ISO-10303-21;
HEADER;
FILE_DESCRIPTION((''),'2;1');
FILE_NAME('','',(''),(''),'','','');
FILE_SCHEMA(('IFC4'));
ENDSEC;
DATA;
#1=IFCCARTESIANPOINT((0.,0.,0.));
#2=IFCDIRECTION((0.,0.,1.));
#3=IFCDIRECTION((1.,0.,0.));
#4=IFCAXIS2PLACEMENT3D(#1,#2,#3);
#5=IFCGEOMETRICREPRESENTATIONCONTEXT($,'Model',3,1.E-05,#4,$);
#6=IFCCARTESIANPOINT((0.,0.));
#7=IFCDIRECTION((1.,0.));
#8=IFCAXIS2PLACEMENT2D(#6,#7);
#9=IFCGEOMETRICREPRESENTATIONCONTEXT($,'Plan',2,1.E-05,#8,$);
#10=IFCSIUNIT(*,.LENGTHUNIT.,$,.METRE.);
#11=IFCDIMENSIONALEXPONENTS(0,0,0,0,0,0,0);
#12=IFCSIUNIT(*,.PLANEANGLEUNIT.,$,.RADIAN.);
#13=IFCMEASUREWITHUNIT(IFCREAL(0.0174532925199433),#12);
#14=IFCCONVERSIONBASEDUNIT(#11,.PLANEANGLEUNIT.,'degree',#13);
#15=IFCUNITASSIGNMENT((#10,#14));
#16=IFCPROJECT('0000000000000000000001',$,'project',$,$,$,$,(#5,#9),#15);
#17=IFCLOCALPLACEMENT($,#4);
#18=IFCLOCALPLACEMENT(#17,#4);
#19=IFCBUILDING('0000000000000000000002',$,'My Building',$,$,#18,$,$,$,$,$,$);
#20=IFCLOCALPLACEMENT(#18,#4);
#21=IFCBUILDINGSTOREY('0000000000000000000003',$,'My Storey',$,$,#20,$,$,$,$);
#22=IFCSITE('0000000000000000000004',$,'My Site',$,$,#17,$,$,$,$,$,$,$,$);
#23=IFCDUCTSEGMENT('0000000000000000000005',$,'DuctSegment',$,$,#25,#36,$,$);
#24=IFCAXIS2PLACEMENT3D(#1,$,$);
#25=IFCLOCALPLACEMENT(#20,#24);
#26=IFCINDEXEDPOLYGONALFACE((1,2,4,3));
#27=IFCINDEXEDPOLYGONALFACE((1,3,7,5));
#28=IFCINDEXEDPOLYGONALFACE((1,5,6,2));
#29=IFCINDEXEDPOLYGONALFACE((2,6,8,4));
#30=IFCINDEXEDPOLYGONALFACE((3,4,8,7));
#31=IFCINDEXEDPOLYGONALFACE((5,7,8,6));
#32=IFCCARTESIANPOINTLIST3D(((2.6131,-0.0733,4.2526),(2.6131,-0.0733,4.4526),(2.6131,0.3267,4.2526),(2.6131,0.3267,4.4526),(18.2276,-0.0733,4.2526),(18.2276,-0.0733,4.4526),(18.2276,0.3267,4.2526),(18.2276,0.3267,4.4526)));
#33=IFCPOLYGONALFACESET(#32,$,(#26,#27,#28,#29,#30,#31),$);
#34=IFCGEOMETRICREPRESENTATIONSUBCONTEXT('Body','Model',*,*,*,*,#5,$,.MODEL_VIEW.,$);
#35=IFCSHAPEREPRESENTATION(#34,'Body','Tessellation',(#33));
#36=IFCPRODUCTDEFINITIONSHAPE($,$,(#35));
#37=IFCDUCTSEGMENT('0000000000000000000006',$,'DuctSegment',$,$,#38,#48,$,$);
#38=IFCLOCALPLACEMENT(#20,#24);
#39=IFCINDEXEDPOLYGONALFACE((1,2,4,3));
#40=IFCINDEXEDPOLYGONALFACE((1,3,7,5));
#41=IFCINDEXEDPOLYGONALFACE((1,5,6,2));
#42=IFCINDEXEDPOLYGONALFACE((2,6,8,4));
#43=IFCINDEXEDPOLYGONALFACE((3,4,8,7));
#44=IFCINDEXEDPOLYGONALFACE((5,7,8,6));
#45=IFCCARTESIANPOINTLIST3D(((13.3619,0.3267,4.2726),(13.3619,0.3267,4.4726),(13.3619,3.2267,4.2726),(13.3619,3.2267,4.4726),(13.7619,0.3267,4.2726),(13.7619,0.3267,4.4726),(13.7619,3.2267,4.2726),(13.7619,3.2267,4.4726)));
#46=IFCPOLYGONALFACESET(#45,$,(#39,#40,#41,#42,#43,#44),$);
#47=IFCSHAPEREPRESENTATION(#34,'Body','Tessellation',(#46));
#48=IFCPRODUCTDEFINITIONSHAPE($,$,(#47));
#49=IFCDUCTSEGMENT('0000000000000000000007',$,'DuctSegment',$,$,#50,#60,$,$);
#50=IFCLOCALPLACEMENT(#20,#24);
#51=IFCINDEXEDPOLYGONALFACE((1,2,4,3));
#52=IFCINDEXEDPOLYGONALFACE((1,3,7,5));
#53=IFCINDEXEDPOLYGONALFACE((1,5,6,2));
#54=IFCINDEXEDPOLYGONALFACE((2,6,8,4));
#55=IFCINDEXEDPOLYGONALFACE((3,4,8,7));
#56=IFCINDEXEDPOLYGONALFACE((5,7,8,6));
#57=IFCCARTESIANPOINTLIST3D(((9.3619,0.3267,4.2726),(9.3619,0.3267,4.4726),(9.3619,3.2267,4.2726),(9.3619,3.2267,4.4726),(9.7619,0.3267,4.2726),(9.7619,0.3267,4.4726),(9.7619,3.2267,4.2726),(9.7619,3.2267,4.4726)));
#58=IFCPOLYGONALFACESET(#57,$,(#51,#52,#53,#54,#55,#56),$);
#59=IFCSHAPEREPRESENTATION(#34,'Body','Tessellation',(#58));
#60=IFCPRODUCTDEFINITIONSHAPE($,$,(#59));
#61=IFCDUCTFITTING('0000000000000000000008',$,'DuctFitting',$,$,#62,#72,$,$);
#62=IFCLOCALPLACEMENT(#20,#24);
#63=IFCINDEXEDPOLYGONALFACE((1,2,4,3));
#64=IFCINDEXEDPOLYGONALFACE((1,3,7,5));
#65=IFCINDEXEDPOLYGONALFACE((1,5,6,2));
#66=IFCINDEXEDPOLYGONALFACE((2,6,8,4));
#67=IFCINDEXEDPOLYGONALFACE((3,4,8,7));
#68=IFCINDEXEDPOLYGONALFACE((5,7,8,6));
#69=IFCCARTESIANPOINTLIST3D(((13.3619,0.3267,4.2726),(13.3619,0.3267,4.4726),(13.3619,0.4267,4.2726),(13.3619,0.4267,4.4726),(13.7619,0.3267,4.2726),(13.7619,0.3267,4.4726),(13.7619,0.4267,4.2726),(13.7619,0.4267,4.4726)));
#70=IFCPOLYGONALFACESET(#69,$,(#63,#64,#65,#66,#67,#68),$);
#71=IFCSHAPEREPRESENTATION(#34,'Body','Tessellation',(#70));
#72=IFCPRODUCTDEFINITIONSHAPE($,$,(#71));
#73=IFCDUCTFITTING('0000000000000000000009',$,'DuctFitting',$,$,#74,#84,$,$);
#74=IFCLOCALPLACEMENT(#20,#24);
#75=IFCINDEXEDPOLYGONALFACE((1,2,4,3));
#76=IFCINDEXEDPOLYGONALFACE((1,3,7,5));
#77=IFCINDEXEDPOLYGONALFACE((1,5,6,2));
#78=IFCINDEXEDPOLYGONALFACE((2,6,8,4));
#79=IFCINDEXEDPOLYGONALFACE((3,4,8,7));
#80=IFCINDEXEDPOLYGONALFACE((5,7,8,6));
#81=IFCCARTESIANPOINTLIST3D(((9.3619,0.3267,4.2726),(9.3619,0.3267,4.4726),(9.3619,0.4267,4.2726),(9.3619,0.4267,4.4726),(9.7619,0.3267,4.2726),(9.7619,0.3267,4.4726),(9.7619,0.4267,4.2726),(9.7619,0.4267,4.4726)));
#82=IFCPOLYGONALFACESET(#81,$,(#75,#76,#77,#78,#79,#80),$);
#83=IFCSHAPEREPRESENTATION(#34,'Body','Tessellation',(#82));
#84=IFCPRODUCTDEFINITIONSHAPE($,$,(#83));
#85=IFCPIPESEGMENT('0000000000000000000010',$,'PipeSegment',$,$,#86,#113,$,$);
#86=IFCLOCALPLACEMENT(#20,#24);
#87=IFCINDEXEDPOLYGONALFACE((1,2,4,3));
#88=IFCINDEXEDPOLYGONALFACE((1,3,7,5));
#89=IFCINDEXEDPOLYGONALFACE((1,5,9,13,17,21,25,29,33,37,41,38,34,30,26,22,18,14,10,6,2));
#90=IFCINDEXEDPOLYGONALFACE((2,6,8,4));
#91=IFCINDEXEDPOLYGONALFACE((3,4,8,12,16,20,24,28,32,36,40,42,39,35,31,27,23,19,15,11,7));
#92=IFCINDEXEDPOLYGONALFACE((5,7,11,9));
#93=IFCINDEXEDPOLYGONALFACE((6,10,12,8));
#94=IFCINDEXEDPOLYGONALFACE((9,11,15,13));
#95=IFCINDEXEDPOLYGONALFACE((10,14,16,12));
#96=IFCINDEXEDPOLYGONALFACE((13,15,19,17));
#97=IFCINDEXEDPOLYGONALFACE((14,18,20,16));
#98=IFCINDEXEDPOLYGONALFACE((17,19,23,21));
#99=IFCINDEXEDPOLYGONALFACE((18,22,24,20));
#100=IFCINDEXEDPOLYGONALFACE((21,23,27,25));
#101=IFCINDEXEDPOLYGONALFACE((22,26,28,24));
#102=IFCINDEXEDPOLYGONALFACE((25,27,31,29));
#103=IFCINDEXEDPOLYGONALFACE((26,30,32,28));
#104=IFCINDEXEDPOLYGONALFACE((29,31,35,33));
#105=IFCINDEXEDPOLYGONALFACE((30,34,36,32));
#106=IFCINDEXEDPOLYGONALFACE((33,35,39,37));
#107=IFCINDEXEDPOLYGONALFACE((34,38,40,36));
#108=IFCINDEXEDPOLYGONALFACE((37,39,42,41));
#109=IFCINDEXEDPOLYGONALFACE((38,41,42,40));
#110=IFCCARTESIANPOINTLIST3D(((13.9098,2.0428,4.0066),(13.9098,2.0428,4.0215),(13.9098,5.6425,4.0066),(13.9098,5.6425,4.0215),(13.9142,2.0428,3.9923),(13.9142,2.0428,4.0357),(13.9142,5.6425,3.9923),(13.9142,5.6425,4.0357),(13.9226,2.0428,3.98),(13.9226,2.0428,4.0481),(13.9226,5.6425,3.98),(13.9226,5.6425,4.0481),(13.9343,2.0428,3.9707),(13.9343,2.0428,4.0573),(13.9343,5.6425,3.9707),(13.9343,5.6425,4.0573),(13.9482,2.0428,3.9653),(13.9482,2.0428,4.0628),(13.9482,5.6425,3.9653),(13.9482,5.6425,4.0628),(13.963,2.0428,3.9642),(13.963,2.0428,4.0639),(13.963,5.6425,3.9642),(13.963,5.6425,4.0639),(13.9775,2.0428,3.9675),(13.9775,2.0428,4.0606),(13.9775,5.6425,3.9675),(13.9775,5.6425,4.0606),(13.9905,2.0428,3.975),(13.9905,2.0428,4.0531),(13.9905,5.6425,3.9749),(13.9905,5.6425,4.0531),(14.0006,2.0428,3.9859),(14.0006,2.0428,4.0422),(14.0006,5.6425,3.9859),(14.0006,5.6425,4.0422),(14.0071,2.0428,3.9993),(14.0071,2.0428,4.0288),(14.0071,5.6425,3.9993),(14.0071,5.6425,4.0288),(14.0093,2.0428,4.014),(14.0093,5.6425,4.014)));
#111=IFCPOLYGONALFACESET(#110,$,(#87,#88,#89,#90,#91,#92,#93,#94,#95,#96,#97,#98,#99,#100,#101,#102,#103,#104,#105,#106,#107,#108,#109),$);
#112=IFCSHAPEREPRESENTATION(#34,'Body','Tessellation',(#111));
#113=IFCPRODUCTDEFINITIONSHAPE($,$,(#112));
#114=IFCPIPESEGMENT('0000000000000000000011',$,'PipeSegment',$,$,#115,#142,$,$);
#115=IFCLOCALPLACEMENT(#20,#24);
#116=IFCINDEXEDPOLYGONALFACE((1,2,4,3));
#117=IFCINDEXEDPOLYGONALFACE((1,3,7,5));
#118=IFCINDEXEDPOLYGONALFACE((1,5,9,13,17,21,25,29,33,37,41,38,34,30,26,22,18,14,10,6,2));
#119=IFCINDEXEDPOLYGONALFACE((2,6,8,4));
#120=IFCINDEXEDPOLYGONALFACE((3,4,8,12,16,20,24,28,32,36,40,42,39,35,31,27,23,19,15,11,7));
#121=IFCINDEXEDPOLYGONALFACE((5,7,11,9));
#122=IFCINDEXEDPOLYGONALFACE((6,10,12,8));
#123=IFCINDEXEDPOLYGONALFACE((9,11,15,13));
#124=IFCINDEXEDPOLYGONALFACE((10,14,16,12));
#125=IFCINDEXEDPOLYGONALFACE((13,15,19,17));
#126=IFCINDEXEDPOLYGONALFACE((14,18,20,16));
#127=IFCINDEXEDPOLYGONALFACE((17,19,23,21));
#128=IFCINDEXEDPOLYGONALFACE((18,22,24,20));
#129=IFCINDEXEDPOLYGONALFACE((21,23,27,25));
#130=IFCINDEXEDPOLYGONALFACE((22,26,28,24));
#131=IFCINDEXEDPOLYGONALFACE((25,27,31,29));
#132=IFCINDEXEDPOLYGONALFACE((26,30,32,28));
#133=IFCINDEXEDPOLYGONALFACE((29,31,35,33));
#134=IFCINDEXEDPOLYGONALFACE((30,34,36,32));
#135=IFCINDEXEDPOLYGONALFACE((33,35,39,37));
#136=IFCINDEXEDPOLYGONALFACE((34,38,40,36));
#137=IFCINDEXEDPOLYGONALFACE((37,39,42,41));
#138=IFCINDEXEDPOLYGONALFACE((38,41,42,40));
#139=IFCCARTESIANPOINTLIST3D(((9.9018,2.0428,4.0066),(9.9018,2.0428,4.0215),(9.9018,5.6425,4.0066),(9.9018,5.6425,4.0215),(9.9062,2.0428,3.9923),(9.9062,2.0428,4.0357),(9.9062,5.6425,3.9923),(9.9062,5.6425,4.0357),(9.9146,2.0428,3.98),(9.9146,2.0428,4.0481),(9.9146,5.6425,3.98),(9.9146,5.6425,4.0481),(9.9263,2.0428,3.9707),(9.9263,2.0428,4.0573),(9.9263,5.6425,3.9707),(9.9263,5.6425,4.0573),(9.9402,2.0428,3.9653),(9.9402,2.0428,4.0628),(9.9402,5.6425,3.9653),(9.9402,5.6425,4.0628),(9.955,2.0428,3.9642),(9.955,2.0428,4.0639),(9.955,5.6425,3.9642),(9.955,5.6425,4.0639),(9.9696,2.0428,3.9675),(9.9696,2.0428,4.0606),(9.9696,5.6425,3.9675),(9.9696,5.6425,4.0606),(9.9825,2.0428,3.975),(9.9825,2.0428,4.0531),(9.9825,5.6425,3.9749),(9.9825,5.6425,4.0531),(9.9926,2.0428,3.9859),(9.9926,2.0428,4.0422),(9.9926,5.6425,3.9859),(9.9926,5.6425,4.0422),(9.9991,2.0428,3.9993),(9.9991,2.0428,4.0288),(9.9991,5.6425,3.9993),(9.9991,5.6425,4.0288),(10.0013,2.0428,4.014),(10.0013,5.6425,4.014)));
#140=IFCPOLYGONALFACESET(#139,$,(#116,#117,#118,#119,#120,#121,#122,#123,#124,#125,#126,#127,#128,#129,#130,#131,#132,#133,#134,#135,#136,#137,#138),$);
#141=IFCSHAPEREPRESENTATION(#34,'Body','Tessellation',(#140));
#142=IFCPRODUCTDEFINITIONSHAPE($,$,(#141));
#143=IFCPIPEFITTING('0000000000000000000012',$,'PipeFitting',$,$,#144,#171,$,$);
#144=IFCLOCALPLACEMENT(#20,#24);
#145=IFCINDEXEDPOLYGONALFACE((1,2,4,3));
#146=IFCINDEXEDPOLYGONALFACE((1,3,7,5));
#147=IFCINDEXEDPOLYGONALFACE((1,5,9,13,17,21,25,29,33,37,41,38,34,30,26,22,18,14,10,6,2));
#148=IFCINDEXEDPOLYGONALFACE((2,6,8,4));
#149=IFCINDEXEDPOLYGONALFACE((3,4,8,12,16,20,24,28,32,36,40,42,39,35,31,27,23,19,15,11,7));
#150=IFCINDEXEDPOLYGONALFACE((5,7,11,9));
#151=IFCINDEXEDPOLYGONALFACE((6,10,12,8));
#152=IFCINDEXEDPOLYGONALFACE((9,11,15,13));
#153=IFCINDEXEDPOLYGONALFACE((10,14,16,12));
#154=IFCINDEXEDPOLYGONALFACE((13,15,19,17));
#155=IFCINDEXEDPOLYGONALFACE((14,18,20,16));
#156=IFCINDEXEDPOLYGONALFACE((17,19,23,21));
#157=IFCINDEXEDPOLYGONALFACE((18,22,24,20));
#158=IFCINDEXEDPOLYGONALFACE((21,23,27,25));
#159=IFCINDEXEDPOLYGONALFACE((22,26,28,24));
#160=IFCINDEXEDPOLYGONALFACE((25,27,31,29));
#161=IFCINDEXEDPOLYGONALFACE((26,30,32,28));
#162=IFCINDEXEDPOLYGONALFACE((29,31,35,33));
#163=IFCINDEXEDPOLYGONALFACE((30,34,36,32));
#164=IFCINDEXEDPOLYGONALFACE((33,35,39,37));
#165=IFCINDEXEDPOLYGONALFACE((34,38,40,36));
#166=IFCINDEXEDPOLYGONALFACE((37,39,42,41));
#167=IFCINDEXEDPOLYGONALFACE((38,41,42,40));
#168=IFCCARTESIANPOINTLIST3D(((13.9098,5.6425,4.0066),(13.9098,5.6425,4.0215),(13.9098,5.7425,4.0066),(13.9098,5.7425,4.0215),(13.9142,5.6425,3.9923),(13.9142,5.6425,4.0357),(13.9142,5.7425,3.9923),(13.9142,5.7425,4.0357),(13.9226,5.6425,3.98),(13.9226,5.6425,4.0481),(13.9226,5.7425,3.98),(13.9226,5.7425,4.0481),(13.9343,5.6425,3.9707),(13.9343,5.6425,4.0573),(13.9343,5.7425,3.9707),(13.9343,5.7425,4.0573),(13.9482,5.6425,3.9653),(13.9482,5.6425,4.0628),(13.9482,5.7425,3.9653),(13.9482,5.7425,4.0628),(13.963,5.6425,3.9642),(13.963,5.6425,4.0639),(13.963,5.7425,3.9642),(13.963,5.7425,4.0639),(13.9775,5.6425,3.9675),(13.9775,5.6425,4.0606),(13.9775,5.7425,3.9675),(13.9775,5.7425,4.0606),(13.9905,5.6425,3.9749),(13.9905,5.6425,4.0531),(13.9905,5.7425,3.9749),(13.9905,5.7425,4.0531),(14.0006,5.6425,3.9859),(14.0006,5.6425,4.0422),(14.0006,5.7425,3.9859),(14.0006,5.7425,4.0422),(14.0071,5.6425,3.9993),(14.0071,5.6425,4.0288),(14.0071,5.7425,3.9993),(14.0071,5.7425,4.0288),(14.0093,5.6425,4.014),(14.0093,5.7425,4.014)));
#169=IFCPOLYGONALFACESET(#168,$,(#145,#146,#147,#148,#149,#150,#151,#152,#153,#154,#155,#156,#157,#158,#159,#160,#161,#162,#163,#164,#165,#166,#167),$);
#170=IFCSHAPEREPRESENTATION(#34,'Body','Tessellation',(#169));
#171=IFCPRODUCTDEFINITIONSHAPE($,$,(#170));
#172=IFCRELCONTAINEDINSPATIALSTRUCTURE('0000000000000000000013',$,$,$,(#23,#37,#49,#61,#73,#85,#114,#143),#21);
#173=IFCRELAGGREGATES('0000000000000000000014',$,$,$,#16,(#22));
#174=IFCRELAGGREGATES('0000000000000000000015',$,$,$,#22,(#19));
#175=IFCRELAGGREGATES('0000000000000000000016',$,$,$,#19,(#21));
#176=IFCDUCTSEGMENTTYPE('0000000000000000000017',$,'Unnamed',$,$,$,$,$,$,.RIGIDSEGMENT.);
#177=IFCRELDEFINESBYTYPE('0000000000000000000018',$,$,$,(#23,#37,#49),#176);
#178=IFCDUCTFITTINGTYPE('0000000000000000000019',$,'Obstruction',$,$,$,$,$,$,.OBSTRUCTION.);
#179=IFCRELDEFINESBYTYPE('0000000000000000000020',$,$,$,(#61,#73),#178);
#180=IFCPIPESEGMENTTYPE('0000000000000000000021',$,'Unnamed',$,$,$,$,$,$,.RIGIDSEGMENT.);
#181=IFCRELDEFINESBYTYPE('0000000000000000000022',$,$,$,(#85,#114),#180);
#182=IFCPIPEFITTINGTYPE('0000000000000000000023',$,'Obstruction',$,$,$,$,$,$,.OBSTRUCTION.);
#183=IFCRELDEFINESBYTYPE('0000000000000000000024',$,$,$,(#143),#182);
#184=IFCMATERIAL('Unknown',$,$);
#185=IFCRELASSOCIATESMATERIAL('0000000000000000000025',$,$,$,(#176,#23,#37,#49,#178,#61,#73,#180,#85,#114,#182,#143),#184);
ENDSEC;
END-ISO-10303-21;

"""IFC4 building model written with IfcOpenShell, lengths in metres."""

from ifc_helpers import new_model, entity, si_unit, converted_unit, frame, origin_with_axes, origin_2d_with_axis, place, context, subcontext, project, spatial, rectangle, circle, extrude, material, material_profile, profile_set, profile_usage, type_object, element, save


model = new_model("IFC4")

# Units and contexts
model_context = context("Model", 3, precision=1e-05, world=origin_with_axes())
plan_context = context("Plan", 2, precision=1e-05, world=origin_2d_with_axis())
body_context_1 = subcontext(model_context, "Body", "Model", "MODEL_VIEW")
ifc_project = project(units=[si_unit("LENGTHUNIT", "METRE"), converted_unit("PLANEANGLEUNIT", "degree", entity("IfcReal", 0.0174532925199433), si_unit("PLANEANGLEUNIT", "RADIAN"), dimensions=[0, 0, 0, 0, 0, 0, 0])], contexts=[model_context, plan_context])

# Site, building, storey
site_placement = place(None, origin_with_axes())
site = spatial("IfcSite", under=ifc_project, at=site_placement, Name="My Site")
building_placement = place(site_placement, origin_with_axes())
building = spatial("IfcBuilding", under=site, at=building_placement, Name="My Building")
storey_placement = place(building_placement, origin_with_axes())
storey = spatial("IfcBuildingStorey", under=building, at=storey_placement, Name="My Storey")

# Shared definitions
ifc_material = material(Name="Unknown")

# Duct segments
ifc_material_profile_1 = material_profile(ifc_material, rectangle(XDim=0.4, YDim=0.2))
ifc_profile_set_1 = profile_set([ifc_material_profile_1])
ifc_profile_usage_1 = profile_usage(ifc_profile_set_1, cardinal=5)
duct_segment_type = type_object("IfcDuctSegmentType", Name="Unnamed", PredefinedType="RIGIDSEGMENT", material=ifc_profile_set_1)
duct_segment_1_placement = place(storey_placement, frame((18.2276, 0.1267, 4.3526), z_axis=(-1.0, 0.0, 0.0), x_axis=(0.0, -1.0, 0.0)))
element("IfcDuctSegment", 1, at=duct_segment_1_placement, inside=storey, type_object=duct_segment_type, material=ifc_profile_usage_1, Name="DuctSegment", context=body_context_1, shape_type="SweptSolid", body=[
    extrude(rectangle(XDim=0.4, YDim=0.2), origin_with_axes(), (0.0, 0.0, 1.0), 15.6145),
])
ifc_profile_usage_2 = profile_usage(ifc_profile_set_1, cardinal=5)
duct_segment_2_placement = place(storey_placement, frame((13.5619, 0.3267, 4.3726), z_axis=(0.0, 1.0, 0.0), x_axis=(-1.0, 0.0, 0.0)))
element("IfcDuctSegment", 2, at=duct_segment_2_placement, inside=storey, type_object=duct_segment_type, material=ifc_profile_usage_2, Name="DuctSegment", context=body_context_1, shape_type="SweptSolid", body=[
    extrude(rectangle(XDim=0.4, YDim=0.2), origin_with_axes(), (0.0, 0.0, 1.0), 2.9),
])
ifc_profile_usage_3 = profile_usage(ifc_profile_set_1, cardinal=5)
duct_segment_3_placement = place(storey_placement, frame((9.5619, 0.3267, 4.3726), z_axis=(0.0, 1.0, 0.0), x_axis=(-1.0, 0.0, 0.0)))
element("IfcDuctSegment", 3, at=duct_segment_3_placement, inside=storey, type_object=duct_segment_type, material=ifc_profile_usage_3, Name="DuctSegment", context=body_context_1, shape_type="SweptSolid", body=[
    extrude(rectangle(XDim=0.4, YDim=0.2), origin_with_axes(), (0.0, 0.0, 1.0), 2.9),
])

# Duct fittings
ifc_material_profile_2 = material_profile(ifc_material, rectangle(XDim=0.4, YDim=0.2))
ifc_profile_set_2 = profile_set([ifc_material_profile_2])
ifc_profile_usage_4 = profile_usage(ifc_profile_set_2, cardinal=5)
duct_fitting_type = type_object("IfcDuctFittingType", Name="Obstruction", PredefinedType="OBSTRUCTION", material=ifc_profile_set_2)
duct_fitting_1_placement = place(storey_placement, frame((13.5619, 0.3267, 4.3726), z_axis=(0.0, 1.0, 0.0), x_axis=(-1.0, 0.0, 0.0)))
element("IfcDuctFitting", 4, at=duct_fitting_1_placement, inside=storey, type_object=duct_fitting_type, material=ifc_profile_usage_4, Name="DuctFitting", context=body_context_1, shape_type="SweptSolid", body=[
    extrude(rectangle(XDim=0.4, YDim=0.2), origin_with_axes(), (0.0, 0.0, 1.0), 0.1),
])
ifc_profile_usage_5 = profile_usage(ifc_profile_set_2, cardinal=5)
duct_fitting_2_placement = place(storey_placement, frame((9.5619, 0.3267, 4.3726), z_axis=(0.0, 1.0, 0.0), x_axis=(-1.0, 0.0, 0.0)))
element("IfcDuctFitting", 5, at=duct_fitting_2_placement, inside=storey, type_object=duct_fitting_type, material=ifc_profile_usage_5, Name="DuctFitting", context=body_context_1, shape_type="SweptSolid", body=[
    extrude(rectangle(XDim=0.4, YDim=0.2), origin_with_axes(), (0.0, 0.0, 1.0), 0.1),
])

# Pipe segments
ifc_material_profile_3 = material_profile(ifc_material, circle(Radius=0.05))
ifc_profile_set_3 = profile_set([ifc_material_profile_3])
ifc_profile_usage_6 = profile_usage(ifc_profile_set_3, cardinal=5)
pipe_segment_type = type_object("IfcPipeSegmentType", Name="Unnamed", PredefinedType="RIGIDSEGMENT", material=ifc_profile_set_3)
pipe_segment_1_placement = place(storey_placement, frame((13.9593, 5.6425, 4.014), z_axis=(0.0, -1.0, 0.0), x_axis=(1.0, 0.0, 0.0)))
element("IfcPipeSegment", 6, at=pipe_segment_1_placement, inside=storey, type_object=pipe_segment_type, material=ifc_profile_usage_6, Name="PipeSegment", context=body_context_1, shape_type="SweptSolid", body=[
    extrude(circle(Radius=0.05), origin_with_axes(), (0.0, 0.0, 1.0), 3.5996),
])
ifc_profile_usage_7 = profile_usage(ifc_profile_set_3, cardinal=5)
pipe_segment_2_placement = place(storey_placement, frame((9.9513, 5.6425, 4.014), z_axis=(0.0, -1.0, 0.0), x_axis=(1.0, 0.0, 0.0)))
element("IfcPipeSegment", 7, at=pipe_segment_2_placement, inside=storey, type_object=pipe_segment_type, material=ifc_profile_usage_7, Name="PipeSegment", context=body_context_1, shape_type="SweptSolid", body=[
    extrude(circle(Radius=0.05), origin_with_axes(), (0.0, 0.0, 1.0), 3.5996),
])

# Pipe fitting
ifc_material_profile_4 = material_profile(ifc_material, circle(Radius=0.05))
ifc_profile_set_4 = profile_set([ifc_material_profile_4])
ifc_profile_usage_8 = profile_usage(ifc_profile_set_4, cardinal=5)
pipe_fitting_type_1 = type_object("IfcPipeFittingType", Name="Obstruction", PredefinedType="OBSTRUCTION", material=ifc_profile_set_4)
pipe_fitting_1_placement = place(storey_placement, frame((13.9593, 5.7425, 4.014), z_axis=(0.0, -1.0, 0.0), x_axis=(1.0, 0.0, 0.0)))
element("IfcPipeFitting", 8, at=pipe_fitting_1_placement, inside=storey, type_object=pipe_fitting_type_1, material=ifc_profile_usage_8, Name="PipeFitting", context=body_context_1, shape_type="SweptSolid", body=[
    extrude(circle(Radius=0.05), origin_with_axes(), (0.0, 0.0, 1.0), 0.1),
])

save(model, "model.ifc")
